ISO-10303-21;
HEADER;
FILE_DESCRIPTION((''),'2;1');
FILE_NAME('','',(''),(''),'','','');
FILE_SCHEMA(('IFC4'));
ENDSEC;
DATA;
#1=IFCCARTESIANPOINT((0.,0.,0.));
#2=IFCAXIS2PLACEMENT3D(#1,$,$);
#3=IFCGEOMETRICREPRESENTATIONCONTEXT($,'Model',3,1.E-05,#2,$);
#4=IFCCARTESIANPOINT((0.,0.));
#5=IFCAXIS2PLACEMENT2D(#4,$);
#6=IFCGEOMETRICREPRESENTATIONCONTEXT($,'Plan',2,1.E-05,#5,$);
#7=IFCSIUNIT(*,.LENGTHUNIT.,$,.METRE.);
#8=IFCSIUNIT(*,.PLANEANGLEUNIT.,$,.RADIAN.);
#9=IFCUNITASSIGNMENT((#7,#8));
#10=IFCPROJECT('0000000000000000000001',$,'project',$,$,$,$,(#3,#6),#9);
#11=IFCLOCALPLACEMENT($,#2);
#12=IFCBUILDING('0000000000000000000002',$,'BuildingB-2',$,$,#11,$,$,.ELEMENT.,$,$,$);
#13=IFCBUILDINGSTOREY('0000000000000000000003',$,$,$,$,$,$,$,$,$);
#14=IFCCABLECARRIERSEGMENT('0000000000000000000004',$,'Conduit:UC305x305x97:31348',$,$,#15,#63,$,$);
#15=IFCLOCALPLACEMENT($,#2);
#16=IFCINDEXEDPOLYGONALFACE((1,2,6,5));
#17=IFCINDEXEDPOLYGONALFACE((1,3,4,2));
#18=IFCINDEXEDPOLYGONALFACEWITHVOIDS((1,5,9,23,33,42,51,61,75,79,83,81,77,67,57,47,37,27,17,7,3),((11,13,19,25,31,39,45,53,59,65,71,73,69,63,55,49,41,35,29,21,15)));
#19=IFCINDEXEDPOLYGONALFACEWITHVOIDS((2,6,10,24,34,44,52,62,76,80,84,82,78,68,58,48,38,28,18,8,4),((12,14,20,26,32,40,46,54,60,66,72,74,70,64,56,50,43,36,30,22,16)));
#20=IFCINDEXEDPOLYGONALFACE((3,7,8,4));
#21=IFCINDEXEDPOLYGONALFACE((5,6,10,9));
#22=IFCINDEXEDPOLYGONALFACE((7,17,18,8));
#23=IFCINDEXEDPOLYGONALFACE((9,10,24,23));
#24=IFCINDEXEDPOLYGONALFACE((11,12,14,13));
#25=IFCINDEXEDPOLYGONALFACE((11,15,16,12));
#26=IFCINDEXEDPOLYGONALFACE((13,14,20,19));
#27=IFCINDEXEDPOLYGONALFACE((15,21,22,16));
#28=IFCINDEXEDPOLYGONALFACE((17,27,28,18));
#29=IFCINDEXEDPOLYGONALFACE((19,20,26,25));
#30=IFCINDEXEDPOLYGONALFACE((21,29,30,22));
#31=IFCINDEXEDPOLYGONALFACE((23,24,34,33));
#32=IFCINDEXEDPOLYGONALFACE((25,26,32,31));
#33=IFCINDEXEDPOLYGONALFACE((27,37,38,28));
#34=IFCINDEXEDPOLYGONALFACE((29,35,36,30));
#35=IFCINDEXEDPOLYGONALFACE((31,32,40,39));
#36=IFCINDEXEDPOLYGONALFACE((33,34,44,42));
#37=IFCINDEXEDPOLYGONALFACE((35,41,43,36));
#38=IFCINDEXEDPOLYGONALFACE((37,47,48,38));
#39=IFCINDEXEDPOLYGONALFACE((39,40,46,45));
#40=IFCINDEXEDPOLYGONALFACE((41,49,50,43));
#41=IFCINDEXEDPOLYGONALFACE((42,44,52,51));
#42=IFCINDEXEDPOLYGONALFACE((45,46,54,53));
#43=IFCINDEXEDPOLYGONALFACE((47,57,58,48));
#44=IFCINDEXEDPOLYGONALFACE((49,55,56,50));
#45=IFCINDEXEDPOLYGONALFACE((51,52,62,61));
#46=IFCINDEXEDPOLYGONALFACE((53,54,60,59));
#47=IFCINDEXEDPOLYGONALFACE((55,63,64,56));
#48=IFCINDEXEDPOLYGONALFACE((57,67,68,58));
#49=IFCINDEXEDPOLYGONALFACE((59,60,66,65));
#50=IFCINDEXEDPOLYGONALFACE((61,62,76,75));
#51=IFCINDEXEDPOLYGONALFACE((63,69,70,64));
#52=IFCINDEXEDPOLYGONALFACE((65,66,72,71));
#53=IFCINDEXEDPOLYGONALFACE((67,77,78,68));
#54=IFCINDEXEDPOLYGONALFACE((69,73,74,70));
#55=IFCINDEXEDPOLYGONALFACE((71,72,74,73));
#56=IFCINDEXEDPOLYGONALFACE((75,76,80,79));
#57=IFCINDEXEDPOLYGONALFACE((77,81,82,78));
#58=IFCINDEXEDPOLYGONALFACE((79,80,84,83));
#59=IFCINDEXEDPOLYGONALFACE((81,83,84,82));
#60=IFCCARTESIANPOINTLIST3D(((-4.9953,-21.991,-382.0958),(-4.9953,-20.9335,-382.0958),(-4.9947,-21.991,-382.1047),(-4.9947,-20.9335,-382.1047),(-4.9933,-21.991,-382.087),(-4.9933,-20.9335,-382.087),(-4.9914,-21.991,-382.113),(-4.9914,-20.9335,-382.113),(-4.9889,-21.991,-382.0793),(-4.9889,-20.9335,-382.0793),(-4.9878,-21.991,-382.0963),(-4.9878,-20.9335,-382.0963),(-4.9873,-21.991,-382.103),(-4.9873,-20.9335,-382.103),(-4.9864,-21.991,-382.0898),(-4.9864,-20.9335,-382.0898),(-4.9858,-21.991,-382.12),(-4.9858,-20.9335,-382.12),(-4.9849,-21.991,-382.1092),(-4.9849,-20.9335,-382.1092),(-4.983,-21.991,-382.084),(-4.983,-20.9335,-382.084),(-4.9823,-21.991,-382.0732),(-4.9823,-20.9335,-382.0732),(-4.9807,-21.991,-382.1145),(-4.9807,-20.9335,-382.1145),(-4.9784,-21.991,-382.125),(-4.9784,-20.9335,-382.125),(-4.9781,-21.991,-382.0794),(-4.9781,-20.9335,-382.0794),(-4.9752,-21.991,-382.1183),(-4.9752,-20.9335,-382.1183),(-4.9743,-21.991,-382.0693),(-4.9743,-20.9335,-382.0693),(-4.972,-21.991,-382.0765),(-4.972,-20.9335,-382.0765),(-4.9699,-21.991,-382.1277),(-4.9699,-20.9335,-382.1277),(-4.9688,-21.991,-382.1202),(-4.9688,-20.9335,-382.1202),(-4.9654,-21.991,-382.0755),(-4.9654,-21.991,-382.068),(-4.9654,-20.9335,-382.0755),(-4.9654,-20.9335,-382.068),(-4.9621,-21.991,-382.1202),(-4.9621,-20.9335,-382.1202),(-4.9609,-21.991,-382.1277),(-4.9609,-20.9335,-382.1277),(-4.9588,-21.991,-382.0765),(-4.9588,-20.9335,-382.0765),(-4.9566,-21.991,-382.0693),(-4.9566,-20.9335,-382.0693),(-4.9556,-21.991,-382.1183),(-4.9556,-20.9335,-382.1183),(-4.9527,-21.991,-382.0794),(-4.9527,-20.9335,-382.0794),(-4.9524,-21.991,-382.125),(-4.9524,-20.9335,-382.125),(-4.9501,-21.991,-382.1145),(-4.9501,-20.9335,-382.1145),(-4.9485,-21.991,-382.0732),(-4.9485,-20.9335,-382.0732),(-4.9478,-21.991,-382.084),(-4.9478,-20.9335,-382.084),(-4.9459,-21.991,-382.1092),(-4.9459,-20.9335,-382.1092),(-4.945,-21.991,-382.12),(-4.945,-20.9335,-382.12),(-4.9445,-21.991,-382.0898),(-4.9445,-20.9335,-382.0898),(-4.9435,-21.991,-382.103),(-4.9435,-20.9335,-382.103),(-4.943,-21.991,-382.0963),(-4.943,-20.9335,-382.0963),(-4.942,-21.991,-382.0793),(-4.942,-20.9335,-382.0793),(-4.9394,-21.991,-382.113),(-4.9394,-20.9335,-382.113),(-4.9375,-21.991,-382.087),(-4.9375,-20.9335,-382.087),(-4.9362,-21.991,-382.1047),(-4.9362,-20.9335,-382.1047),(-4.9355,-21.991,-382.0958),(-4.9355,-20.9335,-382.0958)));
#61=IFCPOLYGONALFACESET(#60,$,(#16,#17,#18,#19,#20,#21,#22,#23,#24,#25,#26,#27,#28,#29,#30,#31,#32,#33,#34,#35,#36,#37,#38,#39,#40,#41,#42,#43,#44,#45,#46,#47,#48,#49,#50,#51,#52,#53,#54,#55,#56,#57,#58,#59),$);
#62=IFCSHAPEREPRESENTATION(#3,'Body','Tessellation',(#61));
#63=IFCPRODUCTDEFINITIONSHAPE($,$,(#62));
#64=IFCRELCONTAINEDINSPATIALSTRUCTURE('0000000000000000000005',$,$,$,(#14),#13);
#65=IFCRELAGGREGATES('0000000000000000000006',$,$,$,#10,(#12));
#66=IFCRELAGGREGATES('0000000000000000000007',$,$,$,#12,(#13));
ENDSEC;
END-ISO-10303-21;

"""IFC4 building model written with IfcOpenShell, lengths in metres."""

from ifc_helpers import new_model, entity, si_unit, origin, origin_2d, place, context, project, spatial, element, save


model = new_model("IFC4")

# Units and contexts
model_context = context("Model", 3, precision=1e-05, world=origin())
plan_context = context("Plan", 2, precision=1e-05, world=origin_2d())
ifc_project = project(units=[si_unit("LENGTHUNIT", "METRE"), si_unit("PLANEANGLEUNIT", "RADIAN")], contexts=[model_context, plan_context])

# Building, storey
building_placement = place(None, origin())
building = spatial("IfcBuilding", under=ifc_project, at=building_placement, Name="BuildingB-2", CompositionType="ELEMENT")
storey = spatial("IfcBuildingStorey", under=building)

# Cable carrier segment
element("IfcCableCarrierSegment", 1, inside=storey, Name="Conduit:UC305x305x97:31348", context=model_context, shape_type="AdvancedSweptSolid", body=[
    entity("IfcSweptDiskSolid", entity("IfcCompositeCurve", [entity("IfcCompositeCurveSegment", "CONTINUOUS", False, entity("IfcPolyline", [entity("IfcCartesianPoint", [4.9654, 20.9335, 382.098]), entity("IfcCartesianPoint", [4.9654, 21.991, 382.098])]))], False), 0.03, 0.0225),
])

save(model, "model.ifc")
